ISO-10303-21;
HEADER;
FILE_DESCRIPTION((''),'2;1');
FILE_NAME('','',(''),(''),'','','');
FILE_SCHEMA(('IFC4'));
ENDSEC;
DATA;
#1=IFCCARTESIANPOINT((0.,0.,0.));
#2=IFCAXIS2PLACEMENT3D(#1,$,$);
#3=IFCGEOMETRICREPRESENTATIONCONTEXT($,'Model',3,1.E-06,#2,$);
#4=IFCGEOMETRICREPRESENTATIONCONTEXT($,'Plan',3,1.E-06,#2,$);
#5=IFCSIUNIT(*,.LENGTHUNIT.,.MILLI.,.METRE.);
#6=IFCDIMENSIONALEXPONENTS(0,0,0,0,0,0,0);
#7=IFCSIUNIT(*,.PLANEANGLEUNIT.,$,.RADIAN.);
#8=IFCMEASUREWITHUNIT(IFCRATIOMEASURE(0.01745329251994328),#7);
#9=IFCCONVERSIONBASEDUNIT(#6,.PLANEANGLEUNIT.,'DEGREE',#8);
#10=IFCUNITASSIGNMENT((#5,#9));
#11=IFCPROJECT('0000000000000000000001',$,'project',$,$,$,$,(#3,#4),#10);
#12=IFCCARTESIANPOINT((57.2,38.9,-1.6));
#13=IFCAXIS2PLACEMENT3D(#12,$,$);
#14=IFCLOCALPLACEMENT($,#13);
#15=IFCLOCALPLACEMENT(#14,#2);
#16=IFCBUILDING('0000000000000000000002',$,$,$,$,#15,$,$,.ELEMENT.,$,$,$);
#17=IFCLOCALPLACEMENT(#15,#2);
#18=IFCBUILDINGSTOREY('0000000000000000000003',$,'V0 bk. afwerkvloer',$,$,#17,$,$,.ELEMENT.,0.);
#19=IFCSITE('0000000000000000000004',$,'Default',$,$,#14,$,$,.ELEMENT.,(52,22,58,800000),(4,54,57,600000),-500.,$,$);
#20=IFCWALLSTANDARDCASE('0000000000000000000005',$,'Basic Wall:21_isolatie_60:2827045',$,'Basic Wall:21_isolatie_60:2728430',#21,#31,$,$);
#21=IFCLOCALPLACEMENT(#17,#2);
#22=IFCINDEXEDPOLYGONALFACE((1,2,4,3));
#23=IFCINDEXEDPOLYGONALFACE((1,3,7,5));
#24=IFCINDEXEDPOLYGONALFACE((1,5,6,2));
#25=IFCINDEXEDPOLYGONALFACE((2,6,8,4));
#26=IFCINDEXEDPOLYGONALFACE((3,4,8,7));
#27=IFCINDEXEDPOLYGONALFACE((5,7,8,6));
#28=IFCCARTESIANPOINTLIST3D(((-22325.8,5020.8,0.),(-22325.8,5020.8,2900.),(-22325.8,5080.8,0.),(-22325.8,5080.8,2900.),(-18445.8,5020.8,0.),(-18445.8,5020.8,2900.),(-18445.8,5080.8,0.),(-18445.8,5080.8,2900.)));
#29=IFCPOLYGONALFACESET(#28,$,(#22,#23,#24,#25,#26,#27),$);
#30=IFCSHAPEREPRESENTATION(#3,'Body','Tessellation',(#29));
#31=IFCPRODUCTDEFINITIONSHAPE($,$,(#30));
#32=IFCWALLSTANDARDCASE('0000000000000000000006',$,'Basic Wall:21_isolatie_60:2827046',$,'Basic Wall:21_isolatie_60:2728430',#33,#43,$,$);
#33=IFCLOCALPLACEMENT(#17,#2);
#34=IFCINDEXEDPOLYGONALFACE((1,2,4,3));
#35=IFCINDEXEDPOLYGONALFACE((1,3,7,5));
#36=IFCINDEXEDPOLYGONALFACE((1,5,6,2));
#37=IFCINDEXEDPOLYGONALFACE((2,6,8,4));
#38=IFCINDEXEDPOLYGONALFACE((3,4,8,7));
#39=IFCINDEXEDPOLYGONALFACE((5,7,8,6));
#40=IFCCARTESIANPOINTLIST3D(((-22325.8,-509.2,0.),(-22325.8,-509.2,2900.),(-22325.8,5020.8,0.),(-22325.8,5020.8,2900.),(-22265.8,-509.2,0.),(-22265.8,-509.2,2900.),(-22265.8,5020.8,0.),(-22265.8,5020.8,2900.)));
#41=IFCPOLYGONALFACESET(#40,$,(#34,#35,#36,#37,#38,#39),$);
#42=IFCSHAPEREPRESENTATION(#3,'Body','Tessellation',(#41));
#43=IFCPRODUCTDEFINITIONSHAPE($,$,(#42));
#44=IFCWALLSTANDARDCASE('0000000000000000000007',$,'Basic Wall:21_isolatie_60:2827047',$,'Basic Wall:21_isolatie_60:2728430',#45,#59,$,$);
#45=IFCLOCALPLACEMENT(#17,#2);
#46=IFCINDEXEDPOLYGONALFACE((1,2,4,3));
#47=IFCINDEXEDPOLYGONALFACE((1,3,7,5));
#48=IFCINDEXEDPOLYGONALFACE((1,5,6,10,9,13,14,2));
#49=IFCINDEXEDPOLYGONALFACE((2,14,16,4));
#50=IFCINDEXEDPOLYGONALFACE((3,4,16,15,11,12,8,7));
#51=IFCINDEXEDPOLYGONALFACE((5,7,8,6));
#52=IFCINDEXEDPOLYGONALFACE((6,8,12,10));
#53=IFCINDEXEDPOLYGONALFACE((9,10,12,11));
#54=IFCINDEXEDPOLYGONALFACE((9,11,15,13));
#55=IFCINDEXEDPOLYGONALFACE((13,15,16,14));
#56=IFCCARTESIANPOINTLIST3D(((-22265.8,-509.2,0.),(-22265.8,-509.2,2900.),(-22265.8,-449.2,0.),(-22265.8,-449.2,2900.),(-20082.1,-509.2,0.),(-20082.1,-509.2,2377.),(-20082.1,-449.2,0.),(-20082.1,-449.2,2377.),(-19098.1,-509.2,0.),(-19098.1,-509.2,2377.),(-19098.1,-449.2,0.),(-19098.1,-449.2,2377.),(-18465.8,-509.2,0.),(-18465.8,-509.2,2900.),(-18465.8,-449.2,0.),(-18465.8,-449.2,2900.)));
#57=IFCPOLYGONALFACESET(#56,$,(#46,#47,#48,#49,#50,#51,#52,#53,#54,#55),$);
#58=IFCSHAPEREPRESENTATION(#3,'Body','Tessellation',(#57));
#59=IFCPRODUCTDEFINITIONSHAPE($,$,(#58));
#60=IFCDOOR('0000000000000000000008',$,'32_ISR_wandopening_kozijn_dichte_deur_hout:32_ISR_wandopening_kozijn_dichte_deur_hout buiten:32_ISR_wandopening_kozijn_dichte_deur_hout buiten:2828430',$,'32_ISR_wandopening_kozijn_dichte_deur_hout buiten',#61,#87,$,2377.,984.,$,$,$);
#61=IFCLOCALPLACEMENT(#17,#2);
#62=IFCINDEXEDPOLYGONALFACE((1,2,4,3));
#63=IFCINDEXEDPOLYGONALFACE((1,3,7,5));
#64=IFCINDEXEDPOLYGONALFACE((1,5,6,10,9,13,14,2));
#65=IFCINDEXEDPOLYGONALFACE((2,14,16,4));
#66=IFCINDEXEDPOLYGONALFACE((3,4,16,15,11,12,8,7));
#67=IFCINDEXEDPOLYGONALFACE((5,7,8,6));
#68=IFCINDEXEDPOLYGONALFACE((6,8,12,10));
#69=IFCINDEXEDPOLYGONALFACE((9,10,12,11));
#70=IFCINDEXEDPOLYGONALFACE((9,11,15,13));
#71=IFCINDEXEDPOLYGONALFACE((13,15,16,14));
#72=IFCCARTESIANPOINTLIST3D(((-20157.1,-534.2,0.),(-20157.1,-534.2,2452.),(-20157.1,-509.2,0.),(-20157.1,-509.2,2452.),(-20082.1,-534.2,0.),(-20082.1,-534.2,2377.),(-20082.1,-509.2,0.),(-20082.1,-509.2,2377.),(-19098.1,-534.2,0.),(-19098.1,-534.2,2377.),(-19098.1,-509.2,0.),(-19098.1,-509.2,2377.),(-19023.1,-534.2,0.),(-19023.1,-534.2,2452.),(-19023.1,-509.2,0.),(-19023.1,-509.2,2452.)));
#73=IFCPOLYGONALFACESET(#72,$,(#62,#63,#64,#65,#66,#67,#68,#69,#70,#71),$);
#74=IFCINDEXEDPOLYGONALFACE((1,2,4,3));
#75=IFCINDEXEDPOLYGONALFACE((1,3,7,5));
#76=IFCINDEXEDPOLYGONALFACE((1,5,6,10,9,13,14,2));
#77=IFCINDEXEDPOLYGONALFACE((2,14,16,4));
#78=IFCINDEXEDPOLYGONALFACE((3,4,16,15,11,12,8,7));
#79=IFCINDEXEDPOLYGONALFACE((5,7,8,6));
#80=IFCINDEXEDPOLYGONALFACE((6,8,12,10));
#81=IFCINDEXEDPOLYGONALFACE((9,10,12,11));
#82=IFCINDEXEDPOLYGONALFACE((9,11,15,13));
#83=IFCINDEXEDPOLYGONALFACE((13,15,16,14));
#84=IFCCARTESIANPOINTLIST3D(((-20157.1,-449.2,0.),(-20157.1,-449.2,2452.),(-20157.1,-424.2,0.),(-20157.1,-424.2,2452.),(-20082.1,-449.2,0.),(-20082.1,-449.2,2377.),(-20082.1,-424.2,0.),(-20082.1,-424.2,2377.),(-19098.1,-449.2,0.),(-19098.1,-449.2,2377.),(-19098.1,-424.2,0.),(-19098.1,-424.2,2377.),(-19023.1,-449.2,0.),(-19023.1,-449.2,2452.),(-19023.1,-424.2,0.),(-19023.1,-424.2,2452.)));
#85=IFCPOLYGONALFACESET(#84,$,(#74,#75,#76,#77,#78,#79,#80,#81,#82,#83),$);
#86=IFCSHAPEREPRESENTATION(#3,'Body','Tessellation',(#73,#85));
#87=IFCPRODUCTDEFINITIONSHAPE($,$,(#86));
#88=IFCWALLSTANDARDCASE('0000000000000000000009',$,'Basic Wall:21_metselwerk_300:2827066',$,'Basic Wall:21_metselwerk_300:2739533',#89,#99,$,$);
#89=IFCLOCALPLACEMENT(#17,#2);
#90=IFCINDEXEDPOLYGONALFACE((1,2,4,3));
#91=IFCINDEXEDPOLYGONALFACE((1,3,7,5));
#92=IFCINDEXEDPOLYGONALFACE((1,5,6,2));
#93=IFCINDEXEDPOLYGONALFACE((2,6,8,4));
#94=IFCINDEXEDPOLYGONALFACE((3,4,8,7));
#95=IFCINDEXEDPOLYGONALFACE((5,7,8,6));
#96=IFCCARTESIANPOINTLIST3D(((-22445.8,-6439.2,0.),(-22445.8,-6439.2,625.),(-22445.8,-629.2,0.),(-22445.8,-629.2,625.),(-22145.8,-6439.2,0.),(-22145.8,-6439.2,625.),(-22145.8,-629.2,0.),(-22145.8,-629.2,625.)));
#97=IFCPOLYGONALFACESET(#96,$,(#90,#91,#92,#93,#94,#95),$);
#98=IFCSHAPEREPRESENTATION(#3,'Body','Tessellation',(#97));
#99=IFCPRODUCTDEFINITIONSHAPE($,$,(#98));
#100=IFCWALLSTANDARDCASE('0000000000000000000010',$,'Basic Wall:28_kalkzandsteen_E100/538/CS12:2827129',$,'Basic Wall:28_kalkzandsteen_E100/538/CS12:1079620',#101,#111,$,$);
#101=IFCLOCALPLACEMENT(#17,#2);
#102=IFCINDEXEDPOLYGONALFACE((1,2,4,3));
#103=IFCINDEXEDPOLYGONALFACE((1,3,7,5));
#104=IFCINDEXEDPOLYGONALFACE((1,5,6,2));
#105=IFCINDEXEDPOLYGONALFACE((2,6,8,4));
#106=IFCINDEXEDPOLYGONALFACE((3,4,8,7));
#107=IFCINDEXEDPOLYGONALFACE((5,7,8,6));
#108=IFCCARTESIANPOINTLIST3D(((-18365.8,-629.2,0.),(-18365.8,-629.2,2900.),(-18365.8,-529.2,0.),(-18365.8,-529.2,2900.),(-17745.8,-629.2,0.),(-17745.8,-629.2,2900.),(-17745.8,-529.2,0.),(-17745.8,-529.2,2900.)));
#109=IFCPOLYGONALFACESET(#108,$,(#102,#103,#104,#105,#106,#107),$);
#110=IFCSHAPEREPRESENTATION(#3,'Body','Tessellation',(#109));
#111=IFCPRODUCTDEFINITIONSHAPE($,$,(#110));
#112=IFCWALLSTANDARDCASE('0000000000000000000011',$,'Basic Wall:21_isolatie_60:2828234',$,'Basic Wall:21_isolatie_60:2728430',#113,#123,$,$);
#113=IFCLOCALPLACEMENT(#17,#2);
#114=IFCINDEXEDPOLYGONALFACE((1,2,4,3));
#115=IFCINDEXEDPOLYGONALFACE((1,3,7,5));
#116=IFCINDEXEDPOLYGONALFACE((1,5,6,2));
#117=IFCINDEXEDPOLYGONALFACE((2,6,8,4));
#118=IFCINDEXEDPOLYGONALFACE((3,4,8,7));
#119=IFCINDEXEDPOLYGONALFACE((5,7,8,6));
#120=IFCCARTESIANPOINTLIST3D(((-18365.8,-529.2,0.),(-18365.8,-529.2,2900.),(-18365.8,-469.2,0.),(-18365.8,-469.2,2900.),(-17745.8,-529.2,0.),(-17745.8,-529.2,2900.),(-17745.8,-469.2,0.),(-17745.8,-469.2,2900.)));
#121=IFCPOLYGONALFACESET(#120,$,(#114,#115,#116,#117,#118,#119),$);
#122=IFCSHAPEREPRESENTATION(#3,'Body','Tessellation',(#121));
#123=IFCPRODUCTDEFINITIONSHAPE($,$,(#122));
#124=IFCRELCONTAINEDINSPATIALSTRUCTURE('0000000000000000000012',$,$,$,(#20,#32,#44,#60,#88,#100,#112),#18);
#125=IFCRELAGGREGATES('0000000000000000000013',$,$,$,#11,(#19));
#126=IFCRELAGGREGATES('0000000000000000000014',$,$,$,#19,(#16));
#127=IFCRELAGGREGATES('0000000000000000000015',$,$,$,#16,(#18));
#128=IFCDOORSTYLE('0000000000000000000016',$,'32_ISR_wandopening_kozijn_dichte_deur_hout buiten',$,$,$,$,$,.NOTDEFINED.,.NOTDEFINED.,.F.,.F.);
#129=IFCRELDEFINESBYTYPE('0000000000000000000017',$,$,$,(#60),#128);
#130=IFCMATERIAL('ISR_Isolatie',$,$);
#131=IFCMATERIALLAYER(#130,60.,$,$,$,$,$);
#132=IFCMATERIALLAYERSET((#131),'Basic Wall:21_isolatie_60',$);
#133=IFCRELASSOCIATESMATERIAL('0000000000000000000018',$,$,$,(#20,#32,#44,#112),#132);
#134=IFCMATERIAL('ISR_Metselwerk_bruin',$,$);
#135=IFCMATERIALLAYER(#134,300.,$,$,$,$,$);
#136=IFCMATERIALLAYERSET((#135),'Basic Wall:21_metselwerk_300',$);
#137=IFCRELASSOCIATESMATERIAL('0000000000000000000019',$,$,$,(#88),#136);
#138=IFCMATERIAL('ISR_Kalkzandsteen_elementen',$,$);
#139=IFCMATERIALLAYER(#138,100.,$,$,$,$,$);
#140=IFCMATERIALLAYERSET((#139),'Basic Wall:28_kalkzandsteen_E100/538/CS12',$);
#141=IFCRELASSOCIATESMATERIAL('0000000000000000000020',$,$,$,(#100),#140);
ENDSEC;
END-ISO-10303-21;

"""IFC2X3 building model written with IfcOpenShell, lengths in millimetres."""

from ifc_helpers import new_model, entity, si_unit, converted_unit, frame, frame_2d, origin, place, context, project, spatial, polyline, rectangle, outline, extrude, source, transform, mapped, material, layer, layer_set, layer_usage, type_object, type_shapes, element, fill, save


model = new_model("IFC2X3")

# Units and contexts
model_context = context("Model", 3, precision=1e-06, world=origin())
plan_context = context("Plan", 3, precision=1e-06, world=origin())
ifc_project = project(units=[si_unit("LENGTHUNIT", "METRE", prefix="MILLI"), converted_unit("PLANEANGLEUNIT", "DEGREE", entity("IfcRatioMeasure", 0.01745329251994328), si_unit("PLANEANGLEUNIT", "RADIAN"), dimensions=[0, 0, 0, 0, 0, 0, 0])], contexts=[model_context, plan_context])

# Site, building, storey
site_placement = place(None, frame((57.2, 38.9, -1.6)))
site = spatial("IfcSite", under=ifc_project, at=site_placement, Name="Default", CompositionType="ELEMENT", RefLatitude=(52, 22, 58, 800000), RefLongitude=(4, 54, 57, 600000), RefElevation=-500.0)
building_placement = place(site_placement, origin())
building = spatial("IfcBuilding", under=site, at=building_placement, CompositionType="ELEMENT")
storey_placement = place(building_placement, origin())
storey = spatial("IfcBuildingStorey", under=building, at=storey_placement, Name="V0 bk. afwerkvloer", CompositionType="ELEMENT", Elevation=0.0)

# Shared definitions
ifc_material_1 = material(Name="ISR_Kalkzandsteen_elementen")
ifc_layer_1 = layer(ifc_material_1, 100.0)
ifc_layer_set_1 = layer_set([ifc_layer_1], Name="Basic Wall:28_kalkzandsteen_E100/538/CS12")

# Shared definitions
ifc_material_2 = material(Name="ISR_Isolatie")
ifc_layer_2 = layer(ifc_material_2, 60.0)
ifc_layer_set_2 = layer_set([ifc_layer_2], Name="Basic Wall:21_isolatie_60")
door_style_1 = type_object("IfcDoorStyle", Name="32_ISR_wandopening_kozijn_dichte_deur_hout buiten", ConstructionType="NOTDEFINED", OperationType="NOTDEFINED", ParameterTakesPrecedence=False, Sizeable=False)
shared_shape_1 = source(origin(), model_context, "Body", "SweptSolid", [
    extrude(outline(polyline([(-1169.7, 492.0), (1207.2, 492.0), (1207.2, 567.0), (-1244.7, 567.0), (-1244.7, -567.0), (1207.2, -567.0), (1207.2, -492.0), (-1169.7, -492.0), (-1169.7, 492.0)])), frame((492.0, 60.0, 1207.2), z_axis=(0.0, 1.0, 0.0), x_axis=(0.0, 0.0, -1.0)), (0.0, 0.0, 1.0), 25.0),
    extrude(outline(polyline([(-567.0, -1244.7), (567.0, -1244.7), (567.0, 1207.2), (492.0, 1207.2), (492.0, -1169.7), (-492.0, -1169.7), (-492.0, 1207.2), (-567.0, 1207.2), (-567.0, -1244.7)])), frame((492.0, -25.0, 1207.2), z_axis=(0.0, 1.0, 0.0), x_axis=(1.0, 0.0, 0.0)), (0.0, 0.0, 1.0), 25.0),
])
type_shapes(door_style_1, [shared_shape_1])

# Walls
ifc_layer_usage_1 = layer_usage(ifc_layer_set_2, "AXIS2", "POSITIVE", -30.0)
wall_1_placement = place(storey_placement, frame((-22325.8, 5050.8, 0.0)))
element("IfcWallStandardCase", 1, at=wall_1_placement, inside=storey, material=ifc_layer_usage_1, Name="Basic Wall:21_isolatie_60:2827045", ObjectType="Basic Wall:21_isolatie_60:2728430", context=model_context, shape_type="SweptSolid", body=[
    extrude(rectangle(XDim=3880.0, YDim=60.0, at=frame_2d((1940.0, 0.0), x_axis=(-1.0, 0.0))), origin(), (0.0, 0.0, 1.0), 2900.0),
])
ifc_layer_usage_2 = layer_usage(ifc_layer_set_2, "AXIS2", "POSITIVE", -30.0)
wall_2_placement = place(storey_placement, frame((-22295.8, -509.2, 0.0), z_axis=(0.0, 0.0, 1.0), x_axis=(0.0, 1.0, 0.0)))
element("IfcWallStandardCase", 2, at=wall_2_placement, inside=storey, material=ifc_layer_usage_2, Name="Basic Wall:21_isolatie_60:2827046", ObjectType="Basic Wall:21_isolatie_60:2728430", context=model_context, shape_type="SweptSolid", body=[
    extrude(rectangle(XDim=5530.0, YDim=60.0, at=frame_2d((2765.0, 0.0), x_axis=(-1.0, 0.0))), origin(), (0.0, 0.0, 1.0), 2900.0),
])

# Wall, opening, door
ifc_layer_usage_3 = layer_usage(ifc_layer_set_2, "AXIS2", "POSITIVE", -30.0)
wall_3_placement = place(storey_placement, frame((-18465.8, -479.2, 0.0), z_axis=(0.0, 0.0, 1.0), x_axis=(-1.0, 0.0, 0.0)))
wall_3 = element("IfcWallStandardCase", 3, at=wall_3_placement, inside=storey, material=ifc_layer_usage_3, Name="Basic Wall:21_isolatie_60:2827047", ObjectType="Basic Wall:21_isolatie_60:2728430", context=model_context, shape_type="SweptSolid", body=[
    extrude(rectangle(XDim=3800.0, YDim=60.0, at=frame_2d((1900.0, 0.0), x_axis=(-1.0, 0.0))), origin(), (0.0, 0.0, 1.0), 2900.0),
])
opening_1_placement = place(wall_3_placement, frame((632.2, -30.0, 0.0)))
opening_1 = element("IfcOpeningElement", 4, at=opening_1_placement, cuts=wall_3, ObjectType="Opening", context=model_context, shape_type="SweptSolid", body=[
    extrude(rectangle(XDim=2377.0, YDim=984.0, at=frame_2d((1188.5, 492.0), x_axis=(1.0, 0.0))), frame((0.0, 0.0, 0.0), z_axis=(0.0, 1.0, 0.0), x_axis=(0.0, 0.0, 1.0)), (0.0, 0.0, 1.0), 60.0),
])
door_1_placement = place(opening_1_placement, origin())
door_1 = element("IfcDoor", 5, at=door_1_placement, inside=storey, type_object=door_style_1, Name="32_ISR_wandopening_kozijn_dichte_deur_hout:32_ISR_wandopening_kozijn_dichte_deur_hout buiten:32_ISR_wandopening_kozijn_dichte_deur_hout buiten:2828430", ObjectType="32_ISR_wandopening_kozijn_dichte_deur_hout buiten", OverallHeight=2377.0, OverallWidth=984.0, context=model_context, shape_type="MappedRepresentation", body=[
    mapped(shared_shape_1, transform((0.0, 0.0, 0.0), scale=1.0)),
])
fill(opening_1, door_1)

# Walls
ifc_material_3 = material(Name="ISR_Metselwerk_bruin")
ifc_layer_3 = layer(ifc_material_3, 300.0)
ifc_layer_set_3 = layer_set([ifc_layer_3], Name="Basic Wall:21_metselwerk_300")
ifc_layer_usage_4 = layer_usage(ifc_layer_set_3, "AXIS2", "NEGATIVE", 150.0)
wall_4_placement = place(storey_placement, frame((-22295.8, -629.2, 0.0), z_axis=(0.0, 0.0, 1.0), x_axis=(0.0, -1.0, 0.0)))
element("IfcWallStandardCase", 6, at=wall_4_placement, inside=storey, material=ifc_layer_usage_4, Name="Basic Wall:21_metselwerk_300:2827066", ObjectType="Basic Wall:21_metselwerk_300:2739533", context=model_context, shape_type="SweptSolid", body=[
    extrude(rectangle(XDim=5810.0, YDim=300.0, at=frame_2d((2905.0, 0.0), x_axis=(-1.0, 0.0))), origin(), (0.0, 0.0, 1.0), 625.0),
])
ifc_layer_usage_5 = layer_usage(ifc_layer_set_1, "AXIS2", "POSITIVE", -50.0)
wall_5_placement = place(storey_placement, frame((-18365.8, -579.2, 0.0)))
element("IfcWallStandardCase", 7, at=wall_5_placement, inside=storey, material=ifc_layer_usage_5, Name="Basic Wall:28_kalkzandsteen_E100/538/CS12:2827129", ObjectType="Basic Wall:28_kalkzandsteen_E100/538/CS12:1079620", context=model_context, shape_type="SweptSolid", body=[
    extrude(rectangle(XDim=620.0, YDim=100.0, at=frame_2d((310.0, 0.0), x_axis=(-1.0, 0.0))), origin(), (0.0, 0.0, 1.0), 2900.0),
])
ifc_layer_usage_6 = layer_usage(ifc_layer_set_2, "AXIS2", "POSITIVE", -30.0)
wall_6_placement = place(storey_placement, frame((-18365.8, -499.2, 0.0)))
element("IfcWallStandardCase", 8, at=wall_6_placement, inside=storey, material=ifc_layer_usage_6, Name="Basic Wall:21_isolatie_60:2828234", ObjectType="Basic Wall:21_isolatie_60:2728430", context=model_context, shape_type="SweptSolid", body=[
    extrude(rectangle(XDim=620.0, YDim=60.0, at=frame_2d((310.0, 0.0), x_axis=(-1.0, 0.0))), origin(), (0.0, 0.0, 1.0), 2900.0),
])

save(model, "model.ifc")
